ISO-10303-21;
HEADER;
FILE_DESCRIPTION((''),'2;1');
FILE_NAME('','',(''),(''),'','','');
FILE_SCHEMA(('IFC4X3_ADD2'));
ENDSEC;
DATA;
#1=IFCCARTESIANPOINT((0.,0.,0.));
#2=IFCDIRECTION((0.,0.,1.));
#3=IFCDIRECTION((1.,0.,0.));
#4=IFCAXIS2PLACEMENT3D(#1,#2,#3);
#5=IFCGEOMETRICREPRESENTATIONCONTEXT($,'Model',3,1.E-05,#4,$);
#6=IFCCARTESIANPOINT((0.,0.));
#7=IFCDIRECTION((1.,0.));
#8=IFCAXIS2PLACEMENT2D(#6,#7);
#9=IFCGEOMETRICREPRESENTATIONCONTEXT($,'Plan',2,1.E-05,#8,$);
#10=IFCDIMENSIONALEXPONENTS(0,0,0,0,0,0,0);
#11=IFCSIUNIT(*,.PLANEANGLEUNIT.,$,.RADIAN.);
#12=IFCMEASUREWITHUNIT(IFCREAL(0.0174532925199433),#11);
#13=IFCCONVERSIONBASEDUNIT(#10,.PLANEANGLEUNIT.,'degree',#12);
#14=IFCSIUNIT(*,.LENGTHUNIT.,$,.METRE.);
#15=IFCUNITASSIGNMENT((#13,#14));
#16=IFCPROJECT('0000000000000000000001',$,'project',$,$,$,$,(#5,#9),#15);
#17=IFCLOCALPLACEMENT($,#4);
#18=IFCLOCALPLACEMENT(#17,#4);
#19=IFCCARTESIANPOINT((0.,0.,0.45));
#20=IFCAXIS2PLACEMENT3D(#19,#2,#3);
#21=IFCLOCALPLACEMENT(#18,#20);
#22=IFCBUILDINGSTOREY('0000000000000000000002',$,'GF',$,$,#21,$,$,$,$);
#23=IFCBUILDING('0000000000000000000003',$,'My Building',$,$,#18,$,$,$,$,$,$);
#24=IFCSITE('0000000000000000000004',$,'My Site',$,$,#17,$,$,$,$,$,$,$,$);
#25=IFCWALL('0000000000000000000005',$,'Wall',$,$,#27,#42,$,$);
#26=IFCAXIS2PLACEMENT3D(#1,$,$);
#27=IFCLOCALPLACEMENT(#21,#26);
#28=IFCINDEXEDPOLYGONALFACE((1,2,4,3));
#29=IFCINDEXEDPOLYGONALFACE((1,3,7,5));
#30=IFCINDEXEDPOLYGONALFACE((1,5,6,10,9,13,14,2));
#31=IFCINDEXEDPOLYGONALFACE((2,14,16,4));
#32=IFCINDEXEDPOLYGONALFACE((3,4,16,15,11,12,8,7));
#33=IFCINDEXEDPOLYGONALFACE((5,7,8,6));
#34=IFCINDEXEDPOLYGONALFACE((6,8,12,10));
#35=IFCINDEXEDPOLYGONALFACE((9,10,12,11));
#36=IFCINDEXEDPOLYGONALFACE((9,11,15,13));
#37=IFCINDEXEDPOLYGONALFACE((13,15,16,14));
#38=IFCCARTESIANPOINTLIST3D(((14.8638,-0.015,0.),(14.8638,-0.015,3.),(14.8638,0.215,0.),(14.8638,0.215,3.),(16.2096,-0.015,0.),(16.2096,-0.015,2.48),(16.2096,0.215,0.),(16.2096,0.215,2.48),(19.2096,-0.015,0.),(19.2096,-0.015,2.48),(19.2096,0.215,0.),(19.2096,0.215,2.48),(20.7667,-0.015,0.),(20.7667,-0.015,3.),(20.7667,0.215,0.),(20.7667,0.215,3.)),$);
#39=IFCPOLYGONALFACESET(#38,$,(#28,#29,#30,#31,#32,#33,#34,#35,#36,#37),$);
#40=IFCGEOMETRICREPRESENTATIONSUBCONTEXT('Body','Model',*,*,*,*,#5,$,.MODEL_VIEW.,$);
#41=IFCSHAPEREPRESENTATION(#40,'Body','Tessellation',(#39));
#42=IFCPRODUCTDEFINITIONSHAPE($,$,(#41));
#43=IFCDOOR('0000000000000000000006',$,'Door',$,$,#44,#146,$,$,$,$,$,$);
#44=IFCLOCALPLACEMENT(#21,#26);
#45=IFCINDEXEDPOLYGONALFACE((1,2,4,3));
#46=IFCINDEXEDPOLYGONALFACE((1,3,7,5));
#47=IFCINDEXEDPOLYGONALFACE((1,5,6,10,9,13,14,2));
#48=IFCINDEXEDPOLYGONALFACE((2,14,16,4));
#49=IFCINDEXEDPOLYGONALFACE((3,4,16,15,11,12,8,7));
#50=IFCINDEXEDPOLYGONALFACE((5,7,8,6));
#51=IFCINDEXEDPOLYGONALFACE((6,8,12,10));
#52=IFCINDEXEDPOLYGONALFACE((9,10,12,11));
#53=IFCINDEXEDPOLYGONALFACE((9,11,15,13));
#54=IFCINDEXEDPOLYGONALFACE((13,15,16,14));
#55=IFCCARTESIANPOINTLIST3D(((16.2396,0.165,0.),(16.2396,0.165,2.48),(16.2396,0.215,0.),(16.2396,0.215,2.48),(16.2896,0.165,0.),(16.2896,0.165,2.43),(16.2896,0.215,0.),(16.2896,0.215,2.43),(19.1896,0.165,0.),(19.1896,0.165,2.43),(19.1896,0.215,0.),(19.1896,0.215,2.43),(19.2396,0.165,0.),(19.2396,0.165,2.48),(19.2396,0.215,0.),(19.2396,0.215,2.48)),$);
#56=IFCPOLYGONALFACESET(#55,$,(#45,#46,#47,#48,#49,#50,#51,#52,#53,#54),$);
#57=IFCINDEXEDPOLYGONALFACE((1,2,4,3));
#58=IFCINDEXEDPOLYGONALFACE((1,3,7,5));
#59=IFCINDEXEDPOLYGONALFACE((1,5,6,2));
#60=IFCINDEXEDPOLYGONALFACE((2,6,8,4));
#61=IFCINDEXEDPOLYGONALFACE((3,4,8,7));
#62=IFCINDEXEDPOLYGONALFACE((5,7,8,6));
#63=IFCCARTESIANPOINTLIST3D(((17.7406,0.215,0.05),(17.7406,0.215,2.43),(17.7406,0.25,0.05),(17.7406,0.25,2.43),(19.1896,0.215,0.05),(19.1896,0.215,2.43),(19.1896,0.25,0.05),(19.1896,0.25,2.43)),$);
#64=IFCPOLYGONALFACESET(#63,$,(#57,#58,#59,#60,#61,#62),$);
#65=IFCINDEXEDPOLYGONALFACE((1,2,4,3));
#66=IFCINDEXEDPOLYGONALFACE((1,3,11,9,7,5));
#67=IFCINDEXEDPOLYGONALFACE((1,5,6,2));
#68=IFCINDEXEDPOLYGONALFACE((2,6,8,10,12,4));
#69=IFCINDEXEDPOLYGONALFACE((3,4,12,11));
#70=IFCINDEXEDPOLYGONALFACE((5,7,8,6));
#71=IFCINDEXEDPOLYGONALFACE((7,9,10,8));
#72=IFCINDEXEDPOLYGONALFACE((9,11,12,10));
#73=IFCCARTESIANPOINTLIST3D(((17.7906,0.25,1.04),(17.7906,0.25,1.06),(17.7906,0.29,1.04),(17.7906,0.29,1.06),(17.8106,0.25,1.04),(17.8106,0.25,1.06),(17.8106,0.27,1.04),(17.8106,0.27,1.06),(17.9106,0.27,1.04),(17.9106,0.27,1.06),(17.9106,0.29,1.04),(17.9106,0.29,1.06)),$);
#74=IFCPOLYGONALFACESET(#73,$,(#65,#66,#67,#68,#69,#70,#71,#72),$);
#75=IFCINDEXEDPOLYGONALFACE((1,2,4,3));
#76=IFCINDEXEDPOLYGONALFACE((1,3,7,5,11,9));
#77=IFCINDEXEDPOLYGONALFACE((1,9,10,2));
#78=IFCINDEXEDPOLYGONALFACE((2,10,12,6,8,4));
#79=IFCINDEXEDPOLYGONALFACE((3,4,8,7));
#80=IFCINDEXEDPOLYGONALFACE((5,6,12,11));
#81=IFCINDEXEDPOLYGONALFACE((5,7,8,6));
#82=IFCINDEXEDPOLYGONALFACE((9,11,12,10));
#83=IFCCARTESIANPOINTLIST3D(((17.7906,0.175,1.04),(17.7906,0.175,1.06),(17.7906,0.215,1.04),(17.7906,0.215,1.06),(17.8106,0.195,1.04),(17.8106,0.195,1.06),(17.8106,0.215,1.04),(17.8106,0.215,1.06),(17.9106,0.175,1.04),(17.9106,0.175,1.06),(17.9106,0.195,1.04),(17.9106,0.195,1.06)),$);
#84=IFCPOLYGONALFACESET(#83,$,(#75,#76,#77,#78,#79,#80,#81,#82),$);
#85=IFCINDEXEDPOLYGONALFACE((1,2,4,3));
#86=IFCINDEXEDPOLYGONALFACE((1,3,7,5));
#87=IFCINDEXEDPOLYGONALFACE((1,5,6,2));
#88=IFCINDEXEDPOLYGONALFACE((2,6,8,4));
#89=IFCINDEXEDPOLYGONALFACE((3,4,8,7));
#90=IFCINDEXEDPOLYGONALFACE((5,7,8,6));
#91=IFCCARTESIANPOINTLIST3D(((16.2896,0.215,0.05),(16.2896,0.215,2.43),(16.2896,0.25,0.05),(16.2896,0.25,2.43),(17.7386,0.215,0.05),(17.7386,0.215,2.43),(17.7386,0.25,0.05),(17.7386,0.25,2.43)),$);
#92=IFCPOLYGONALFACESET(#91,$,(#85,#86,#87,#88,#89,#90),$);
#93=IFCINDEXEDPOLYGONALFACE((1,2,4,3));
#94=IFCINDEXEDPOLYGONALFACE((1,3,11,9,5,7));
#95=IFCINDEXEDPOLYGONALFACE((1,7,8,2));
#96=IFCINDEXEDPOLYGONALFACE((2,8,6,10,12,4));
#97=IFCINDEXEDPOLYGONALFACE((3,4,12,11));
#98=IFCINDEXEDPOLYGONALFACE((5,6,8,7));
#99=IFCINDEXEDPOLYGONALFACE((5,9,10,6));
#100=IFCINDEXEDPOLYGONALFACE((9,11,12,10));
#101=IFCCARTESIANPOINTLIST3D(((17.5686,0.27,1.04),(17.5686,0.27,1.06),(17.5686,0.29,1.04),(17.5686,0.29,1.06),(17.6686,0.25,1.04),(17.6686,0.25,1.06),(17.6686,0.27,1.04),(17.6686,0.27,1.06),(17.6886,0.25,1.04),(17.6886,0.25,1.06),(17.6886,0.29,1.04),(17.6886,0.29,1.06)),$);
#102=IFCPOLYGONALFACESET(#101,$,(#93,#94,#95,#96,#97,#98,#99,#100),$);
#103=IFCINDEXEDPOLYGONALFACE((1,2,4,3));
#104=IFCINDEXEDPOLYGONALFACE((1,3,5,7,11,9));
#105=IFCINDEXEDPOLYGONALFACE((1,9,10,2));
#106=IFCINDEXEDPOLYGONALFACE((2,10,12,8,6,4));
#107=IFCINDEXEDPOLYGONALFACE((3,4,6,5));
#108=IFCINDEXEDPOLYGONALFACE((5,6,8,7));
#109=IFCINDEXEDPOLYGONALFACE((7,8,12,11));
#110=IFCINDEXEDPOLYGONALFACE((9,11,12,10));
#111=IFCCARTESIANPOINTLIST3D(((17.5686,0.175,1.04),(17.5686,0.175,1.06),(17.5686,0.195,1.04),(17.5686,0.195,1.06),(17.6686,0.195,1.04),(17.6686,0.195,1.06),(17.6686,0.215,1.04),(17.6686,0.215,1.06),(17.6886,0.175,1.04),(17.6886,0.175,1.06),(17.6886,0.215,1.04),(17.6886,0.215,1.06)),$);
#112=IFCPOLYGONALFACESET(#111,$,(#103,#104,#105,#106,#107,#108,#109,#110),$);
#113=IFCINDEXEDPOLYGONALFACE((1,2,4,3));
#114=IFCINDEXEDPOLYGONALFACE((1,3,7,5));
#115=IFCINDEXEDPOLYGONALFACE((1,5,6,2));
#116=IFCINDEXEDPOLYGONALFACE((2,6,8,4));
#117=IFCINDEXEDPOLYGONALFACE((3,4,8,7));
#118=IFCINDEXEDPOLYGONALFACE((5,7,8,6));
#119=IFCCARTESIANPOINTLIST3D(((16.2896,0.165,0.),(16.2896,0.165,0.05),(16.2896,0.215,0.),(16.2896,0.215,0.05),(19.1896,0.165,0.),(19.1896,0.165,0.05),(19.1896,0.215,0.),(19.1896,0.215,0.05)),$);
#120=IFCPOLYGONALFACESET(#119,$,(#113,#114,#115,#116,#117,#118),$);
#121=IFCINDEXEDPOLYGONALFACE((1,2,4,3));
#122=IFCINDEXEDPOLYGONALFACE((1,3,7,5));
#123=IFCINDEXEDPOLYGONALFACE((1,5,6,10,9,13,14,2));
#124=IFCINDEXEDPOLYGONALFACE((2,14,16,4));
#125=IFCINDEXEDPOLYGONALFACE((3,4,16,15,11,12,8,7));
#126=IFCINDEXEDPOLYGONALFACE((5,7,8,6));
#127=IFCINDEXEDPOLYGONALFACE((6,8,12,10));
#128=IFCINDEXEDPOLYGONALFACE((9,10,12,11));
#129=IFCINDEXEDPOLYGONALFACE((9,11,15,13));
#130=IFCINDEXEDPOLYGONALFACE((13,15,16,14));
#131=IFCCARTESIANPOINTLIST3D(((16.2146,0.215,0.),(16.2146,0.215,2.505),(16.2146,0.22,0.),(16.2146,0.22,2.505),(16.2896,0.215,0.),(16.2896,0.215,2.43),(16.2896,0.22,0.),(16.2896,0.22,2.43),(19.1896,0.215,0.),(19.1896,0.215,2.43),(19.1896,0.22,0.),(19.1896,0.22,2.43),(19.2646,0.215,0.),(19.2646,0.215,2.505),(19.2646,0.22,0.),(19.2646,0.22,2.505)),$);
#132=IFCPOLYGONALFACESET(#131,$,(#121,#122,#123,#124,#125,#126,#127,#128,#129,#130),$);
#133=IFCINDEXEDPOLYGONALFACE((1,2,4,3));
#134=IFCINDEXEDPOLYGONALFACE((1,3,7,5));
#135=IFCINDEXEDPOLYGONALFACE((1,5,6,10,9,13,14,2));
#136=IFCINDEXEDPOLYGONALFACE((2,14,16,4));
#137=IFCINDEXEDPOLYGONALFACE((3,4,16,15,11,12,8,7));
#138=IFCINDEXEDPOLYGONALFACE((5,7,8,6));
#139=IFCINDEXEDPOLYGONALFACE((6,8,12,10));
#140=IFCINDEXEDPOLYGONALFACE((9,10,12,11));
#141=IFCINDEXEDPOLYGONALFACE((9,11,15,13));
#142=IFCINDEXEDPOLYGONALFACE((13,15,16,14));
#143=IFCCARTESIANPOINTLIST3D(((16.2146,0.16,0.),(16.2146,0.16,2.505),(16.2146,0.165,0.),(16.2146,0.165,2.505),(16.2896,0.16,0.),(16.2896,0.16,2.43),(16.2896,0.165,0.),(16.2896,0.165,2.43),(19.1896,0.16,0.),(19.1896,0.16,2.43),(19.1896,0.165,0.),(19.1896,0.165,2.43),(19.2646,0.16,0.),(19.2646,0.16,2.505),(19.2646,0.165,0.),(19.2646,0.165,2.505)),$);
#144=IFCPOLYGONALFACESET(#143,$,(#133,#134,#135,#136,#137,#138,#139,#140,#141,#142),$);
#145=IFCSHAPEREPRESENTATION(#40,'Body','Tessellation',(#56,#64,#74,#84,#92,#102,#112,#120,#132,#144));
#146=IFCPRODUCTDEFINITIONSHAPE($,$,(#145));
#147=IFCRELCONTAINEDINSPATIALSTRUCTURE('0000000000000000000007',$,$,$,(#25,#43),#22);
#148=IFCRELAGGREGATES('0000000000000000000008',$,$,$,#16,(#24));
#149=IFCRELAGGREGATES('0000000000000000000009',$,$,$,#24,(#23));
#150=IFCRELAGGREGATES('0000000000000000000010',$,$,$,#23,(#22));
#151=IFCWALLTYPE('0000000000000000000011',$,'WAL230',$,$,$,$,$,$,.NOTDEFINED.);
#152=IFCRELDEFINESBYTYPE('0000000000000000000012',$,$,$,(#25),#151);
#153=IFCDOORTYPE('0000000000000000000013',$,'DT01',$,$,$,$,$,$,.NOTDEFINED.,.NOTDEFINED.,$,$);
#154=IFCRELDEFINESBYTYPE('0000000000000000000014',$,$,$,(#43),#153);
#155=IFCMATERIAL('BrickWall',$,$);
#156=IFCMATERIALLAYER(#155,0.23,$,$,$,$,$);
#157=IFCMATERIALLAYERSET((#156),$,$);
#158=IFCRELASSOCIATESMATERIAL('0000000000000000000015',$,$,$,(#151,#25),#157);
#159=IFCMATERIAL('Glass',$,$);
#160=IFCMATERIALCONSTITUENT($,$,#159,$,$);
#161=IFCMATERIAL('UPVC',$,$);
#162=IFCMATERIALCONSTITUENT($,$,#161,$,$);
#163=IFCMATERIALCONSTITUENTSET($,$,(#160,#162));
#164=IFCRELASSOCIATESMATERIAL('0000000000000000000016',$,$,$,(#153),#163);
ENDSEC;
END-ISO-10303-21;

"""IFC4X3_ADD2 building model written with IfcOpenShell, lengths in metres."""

from ifc_helpers import new_model, entity, si_unit, converted_unit, frame, origin_with_axes, origin_2d_with_axis, place, context, subcontext, project, spatial, line, indexed_curve, outline, extrude, shape, source, transform, mapped, material, layer, layer_set, layer_usage, constituent, constituent_set, type_object, type_shapes, element, fill, save


model = new_model("IFC4X3_ADD2")

# Units and contexts
model_context = context("Model", 3, precision=1e-05, world=origin_with_axes())
plan_context = context("Plan", 2, precision=1e-05, world=origin_2d_with_axis())
body_context_1 = subcontext(model_context, "Body", "Model", "MODEL_VIEW")
body_context_2 = subcontext(plan_context, "Body", "Plan", "PLAN_VIEW")
ifc_project = project(units=[converted_unit("PLANEANGLEUNIT", "degree", entity("IfcReal", 0.0174532925199433), si_unit("PLANEANGLEUNIT", "RADIAN"), dimensions=[0, 0, 0, 0, 0, 0, 0]), si_unit("LENGTHUNIT", "METRE")], contexts=[model_context, plan_context])

# Site, building, storey
site_placement = place(None, origin_with_axes())
site = spatial("IfcSite", under=ifc_project, at=site_placement, Name="My Site")
building_placement = place(site_placement, origin_with_axes())
building = spatial("IfcBuilding", under=site, at=building_placement, Name="My Building")
storey_placement = place(building_placement, frame((0.0, 0.0, 0.45), z_axis=(0.0, 0.0, 1.0), x_axis=(1.0, 0.0, 0.0)))
storey = spatial("IfcBuildingStorey", under=building, at=storey_placement, Name="GF")

# Shared definitions
ifc_material_1 = material(Name="BrickWall")
ifc_layer_1 = layer(ifc_material_1, 0.23)
ifc_layer_set_1 = layer_set([ifc_layer_1])
wall_type_1 = type_object("IfcWallType", Name="WAL230", PredefinedType="NOTDEFINED", material=ifc_layer_set_1)
shared_shape_1 = source(origin_with_axes(), body_context_1, "Body", "SweptSolid", [
    extrude(outline(indexed_curve([(0.0, 0.0), (3.0, 0.0), (3.0, 2.48), (0.0, 2.48)], segments=[line(1, 2, 3, 4, 1)])), frame((0.0, -0.6, 0.0), z_axis=(0.0, -1.0, 0.0), x_axis=(1.0, 0.0, 0.0)), (0.0, 0.0, -1.0), 1.2),
])
ifc_material_2 = material(Name="Glass")
ifc_constituent_1 = constituent(ifc_material_2)
ifc_material_3 = material(Name="UPVC")
ifc_constituent_2 = constituent(ifc_material_3)
ifc_constituent_set = constituent_set(constituents=[ifc_constituent_1, ifc_constituent_2])
door_type_1 = type_object("IfcDoorType", Name="DT01", OperationType="NOTDEFINED", PredefinedType="NOTDEFINED", material=ifc_constituent_set)
shared_shape_2 = source(origin_with_axes(), body_context_1, "Body", "SweptSolid", [
    extrude(outline(indexed_curve([(3.0, 0.0), (3.0, 2.48), (0.0, 2.48), (0.0, 0.0), (0.05, 0.0), (0.05, 2.43), (2.95, 2.43), (2.95, 0.0)], segments=[line(5, 4), line(4, 3), line(3, 2), line(2, 1), line(1, 8), line(8, 7), line(7, 6), line(6, 5)], self_intersect=False)), frame((0.0, 0.0, 0.0), z_axis=(0.0, -1.0, 0.0), x_axis=(1.0, 0.0, 0.0)), (0.0, 0.0, -1.0), 0.05),
    extrude(outline(indexed_curve([(0.0, 0.0), (1.449, 0.0), (1.449, 0.035), (0.0, 0.035)], segments=[line(1, 2, 3, 4, 1)])), frame((0.05, -0.035, 0.05), z_axis=(0.0, 0.0, 1.0), x_axis=(1.0, 0.0, 0.0)), (0.0, 0.0, 1.0), 2.38),
    extrude(outline(indexed_curve([(0.0, 0.0), (0.0, -0.04), (-0.12, -0.04), (-0.12, -0.02), (-0.02, -0.02), (-0.02, 0.0)], segments=[line(1, 2, 3, 4, 5, 6, 1)])), frame((1.449, -0.035, 1.04), z_axis=(0.0, 0.0, 1.0), x_axis=(1.0, 0.0, 0.0)), (0.0, 0.0, 1.0), 0.02),
    extrude(outline(indexed_curve([(0.0, 0.0), (0.0, 0.04), (-0.12, 0.04), (-0.12, 0.02), (-0.02, 0.02), (-0.02, 0.0)], segments=[line(1, 2, 3, 4, 5, 6, 1)])), frame((1.449, 0.0, 1.04), z_axis=(0.0, 0.0, 1.0), x_axis=(1.0, 0.0, 0.0)), (0.0, 0.0, 1.0), 0.02),
    extrude(outline(indexed_curve([(0.0, 0.0), (-1.449, 0.0), (-1.449, 0.035), (0.0, 0.035)], segments=[line(1, 2, 3, 4, 1)])), frame((2.95, -0.035, 0.05), z_axis=(0.0, 0.0, 1.0), x_axis=(1.0, 0.0, 0.0)), (0.0, 0.0, 1.0), 2.38),
    extrude(outline(indexed_curve([(0.0, 0.0), (0.0, -0.04), (0.12, -0.04), (0.12, -0.02), (0.02, -0.02), (0.02, 0.0)], segments=[line(1, 2, 3, 4, 5, 6, 1)])), frame((1.551, -0.035, 1.04), z_axis=(0.0, 0.0, 1.0), x_axis=(1.0, 0.0, 0.0)), (0.0, 0.0, 1.0), 0.02),
    extrude(outline(indexed_curve([(0.0, 0.0), (0.0, 0.04), (0.12, 0.04), (0.12, 0.02), (0.02, 0.02), (0.02, 0.0)], segments=[line(1, 2, 3, 4, 5, 6, 1)])), frame((1.551, 0.0, 1.04), z_axis=(0.0, 0.0, 1.0), x_axis=(1.0, 0.0, 0.0)), (0.0, 0.0, 1.0), 0.02),
    extrude(outline(indexed_curve([(0.0, 0.0), (2.9, 0.0), (2.9, 0.05), (0.0, 0.05)], segments=[line(1, 2, 3, 4, 1)])), frame((0.05, 0.0, 0.0), z_axis=(0.0, 0.0, 1.0), x_axis=(1.0, 0.0, 0.0)), (0.0, 0.0, 1.0), 0.05),
    extrude(outline(indexed_curve([(0.0, 0.0), (0.0, 2.505), (3.05, 2.505), (3.05, 0.0), (2.975, 0.0), (2.975, 2.43), (0.075, 2.43), (0.075, 0.0)], segments=[line(1, 2, 3, 4, 5, 6, 7, 8, 1)])), frame((-0.025, -0.005, 0.0), z_axis=(0.0, -1.0, 0.0), x_axis=(1.0, 0.0, 0.0)), (0.0, 0.0, -1.0), 0.005),
    extrude(outline(indexed_curve([(0.0, 0.0), (0.0, 2.505), (3.05, 2.505), (3.05, 0.0), (2.975, 0.0), (2.975, 2.43), (0.075, 2.43), (0.075, 0.0)], segments=[line(1, 2, 3, 4, 5, 6, 7, 8, 1)])), frame((-0.025, 0.05, 0.0), z_axis=(0.0, -1.0, 0.0), x_axis=(1.0, 0.0, 0.0)), (0.0, 0.0, -1.0), 0.005),
])
shared_shape_3 = source(origin_with_axes(), body_context_2, "Body", "Curve2D", [
    entity("IfcIndexedPolyCurve", entity("IfcCartesianPointList2D", [[0.0, 0.0], [0.05, 0.0], [0.05, 0.05], [0.0, 0.05]]), [entity("IfcLineIndex", [1, 2, 3, 4, 1])]),
    entity("IfcIndexedPolyCurve", entity("IfcCartesianPointList2D", [[3.0, 0.0], [2.95, 0.0], [2.95, 0.05], [3.0, 0.05]]), [entity("IfcLineIndex", [1, 2, 3, 4, 1])]),
    entity("IfcIndexedPolyCurve", entity("IfcCartesianPointList2D", [[-0.675, -0.035], [0.775, -0.035], [0.775, 0.0], [-0.675, 0.0]]), [entity("IfcLineIndex", [1, 2, 3, 4, 1])]),
    entity("IfcIndexedPolyCurve", entity("IfcCartesianPointList2D", [[3.675, -0.035], [2.225, -0.035], [2.225, 0.0], [3.675, 0.0]]), [entity("IfcLineIndex", [1, 2, 3, 4, 1])]),
])
type_shapes(door_type_1, [shared_shape_2, shared_shape_3])

# Wall, opening, door
ifc_layer_usage_1 = layer_usage(ifc_layer_set_1, "AXIS2", "POSITIVE", 0.0)
wall_1_placement = place(storey_placement, frame((20.7667, 0.215, 0.0), z_axis=(0.0, 0.0, 1.0), x_axis=(-1.0, 0.0, 0.0)))
wall_1 = element("IfcWall", 1, at=wall_1_placement, inside=storey, type_object=wall_type_1, material=ifc_layer_usage_1, Name="Wall", context=body_context_1, shape_type="SweptSolid", body=[
    extrude(outline(indexed_curve([(0.0, 0.0), (0.0, 0.23), (5.9029, 0.23), (5.9029, 0.0), (0.0, 0.0)], self_intersect=False)), origin_with_axes(), (0.0, 0.0, 1.0), 3.0),
])
opening_1_placement = place(wall_1_placement, frame((1.5572, 0.0, 0.0), z_axis=(0.0, 0.0, 1.0), x_axis=(1.0, 0.0, 0.0)))
opening_1 = element("IfcOpeningElement", 2, at=opening_1_placement, cuts=wall_1, PredefinedType="OPENING", context=body_context_1, shape_type="MappedRepresentation", body=[
    mapped(shared_shape_1, transform((0.0, 0.0, 0.0), x_axis=(1.0, 0.0, 0.0), y_axis=(0.0, 1.0, 0.0), z_axis=(0.0, 0.0, 1.0), scale=1.0)),
])
door_1_placement = place(opening_1_placement, frame((-0.03, 0.0, 0.0), z_axis=(0.0, 0.0, 1.0), x_axis=(1.0, 0.0, 0.0)))
door_1 = element("IfcDoor", 3, at=door_1_placement, inside=storey, type_object=door_type_1, Name="Door", shapes=[
    shape(body_context_1, "Body", "MappedRepresentation", [mapped(shared_shape_2, transform((0.0, 0.0, 0.0), x_axis=(1.0, 0.0, 0.0), y_axis=(0.0, 1.0, 0.0), z_axis=(0.0, 0.0, 1.0), scale=1.0))]),
    shape(body_context_2, "Body", "MappedRepresentation", [mapped(shared_shape_3, transform((0.0, 0.0, 0.0), x_axis=(1.0, 0.0, 0.0), y_axis=(0.0, 1.0, 0.0), z_axis=(0.0, 0.0, 1.0), scale=1.0))]),
])
fill(opening_1, door_1)

save(model, "model.ifc")
